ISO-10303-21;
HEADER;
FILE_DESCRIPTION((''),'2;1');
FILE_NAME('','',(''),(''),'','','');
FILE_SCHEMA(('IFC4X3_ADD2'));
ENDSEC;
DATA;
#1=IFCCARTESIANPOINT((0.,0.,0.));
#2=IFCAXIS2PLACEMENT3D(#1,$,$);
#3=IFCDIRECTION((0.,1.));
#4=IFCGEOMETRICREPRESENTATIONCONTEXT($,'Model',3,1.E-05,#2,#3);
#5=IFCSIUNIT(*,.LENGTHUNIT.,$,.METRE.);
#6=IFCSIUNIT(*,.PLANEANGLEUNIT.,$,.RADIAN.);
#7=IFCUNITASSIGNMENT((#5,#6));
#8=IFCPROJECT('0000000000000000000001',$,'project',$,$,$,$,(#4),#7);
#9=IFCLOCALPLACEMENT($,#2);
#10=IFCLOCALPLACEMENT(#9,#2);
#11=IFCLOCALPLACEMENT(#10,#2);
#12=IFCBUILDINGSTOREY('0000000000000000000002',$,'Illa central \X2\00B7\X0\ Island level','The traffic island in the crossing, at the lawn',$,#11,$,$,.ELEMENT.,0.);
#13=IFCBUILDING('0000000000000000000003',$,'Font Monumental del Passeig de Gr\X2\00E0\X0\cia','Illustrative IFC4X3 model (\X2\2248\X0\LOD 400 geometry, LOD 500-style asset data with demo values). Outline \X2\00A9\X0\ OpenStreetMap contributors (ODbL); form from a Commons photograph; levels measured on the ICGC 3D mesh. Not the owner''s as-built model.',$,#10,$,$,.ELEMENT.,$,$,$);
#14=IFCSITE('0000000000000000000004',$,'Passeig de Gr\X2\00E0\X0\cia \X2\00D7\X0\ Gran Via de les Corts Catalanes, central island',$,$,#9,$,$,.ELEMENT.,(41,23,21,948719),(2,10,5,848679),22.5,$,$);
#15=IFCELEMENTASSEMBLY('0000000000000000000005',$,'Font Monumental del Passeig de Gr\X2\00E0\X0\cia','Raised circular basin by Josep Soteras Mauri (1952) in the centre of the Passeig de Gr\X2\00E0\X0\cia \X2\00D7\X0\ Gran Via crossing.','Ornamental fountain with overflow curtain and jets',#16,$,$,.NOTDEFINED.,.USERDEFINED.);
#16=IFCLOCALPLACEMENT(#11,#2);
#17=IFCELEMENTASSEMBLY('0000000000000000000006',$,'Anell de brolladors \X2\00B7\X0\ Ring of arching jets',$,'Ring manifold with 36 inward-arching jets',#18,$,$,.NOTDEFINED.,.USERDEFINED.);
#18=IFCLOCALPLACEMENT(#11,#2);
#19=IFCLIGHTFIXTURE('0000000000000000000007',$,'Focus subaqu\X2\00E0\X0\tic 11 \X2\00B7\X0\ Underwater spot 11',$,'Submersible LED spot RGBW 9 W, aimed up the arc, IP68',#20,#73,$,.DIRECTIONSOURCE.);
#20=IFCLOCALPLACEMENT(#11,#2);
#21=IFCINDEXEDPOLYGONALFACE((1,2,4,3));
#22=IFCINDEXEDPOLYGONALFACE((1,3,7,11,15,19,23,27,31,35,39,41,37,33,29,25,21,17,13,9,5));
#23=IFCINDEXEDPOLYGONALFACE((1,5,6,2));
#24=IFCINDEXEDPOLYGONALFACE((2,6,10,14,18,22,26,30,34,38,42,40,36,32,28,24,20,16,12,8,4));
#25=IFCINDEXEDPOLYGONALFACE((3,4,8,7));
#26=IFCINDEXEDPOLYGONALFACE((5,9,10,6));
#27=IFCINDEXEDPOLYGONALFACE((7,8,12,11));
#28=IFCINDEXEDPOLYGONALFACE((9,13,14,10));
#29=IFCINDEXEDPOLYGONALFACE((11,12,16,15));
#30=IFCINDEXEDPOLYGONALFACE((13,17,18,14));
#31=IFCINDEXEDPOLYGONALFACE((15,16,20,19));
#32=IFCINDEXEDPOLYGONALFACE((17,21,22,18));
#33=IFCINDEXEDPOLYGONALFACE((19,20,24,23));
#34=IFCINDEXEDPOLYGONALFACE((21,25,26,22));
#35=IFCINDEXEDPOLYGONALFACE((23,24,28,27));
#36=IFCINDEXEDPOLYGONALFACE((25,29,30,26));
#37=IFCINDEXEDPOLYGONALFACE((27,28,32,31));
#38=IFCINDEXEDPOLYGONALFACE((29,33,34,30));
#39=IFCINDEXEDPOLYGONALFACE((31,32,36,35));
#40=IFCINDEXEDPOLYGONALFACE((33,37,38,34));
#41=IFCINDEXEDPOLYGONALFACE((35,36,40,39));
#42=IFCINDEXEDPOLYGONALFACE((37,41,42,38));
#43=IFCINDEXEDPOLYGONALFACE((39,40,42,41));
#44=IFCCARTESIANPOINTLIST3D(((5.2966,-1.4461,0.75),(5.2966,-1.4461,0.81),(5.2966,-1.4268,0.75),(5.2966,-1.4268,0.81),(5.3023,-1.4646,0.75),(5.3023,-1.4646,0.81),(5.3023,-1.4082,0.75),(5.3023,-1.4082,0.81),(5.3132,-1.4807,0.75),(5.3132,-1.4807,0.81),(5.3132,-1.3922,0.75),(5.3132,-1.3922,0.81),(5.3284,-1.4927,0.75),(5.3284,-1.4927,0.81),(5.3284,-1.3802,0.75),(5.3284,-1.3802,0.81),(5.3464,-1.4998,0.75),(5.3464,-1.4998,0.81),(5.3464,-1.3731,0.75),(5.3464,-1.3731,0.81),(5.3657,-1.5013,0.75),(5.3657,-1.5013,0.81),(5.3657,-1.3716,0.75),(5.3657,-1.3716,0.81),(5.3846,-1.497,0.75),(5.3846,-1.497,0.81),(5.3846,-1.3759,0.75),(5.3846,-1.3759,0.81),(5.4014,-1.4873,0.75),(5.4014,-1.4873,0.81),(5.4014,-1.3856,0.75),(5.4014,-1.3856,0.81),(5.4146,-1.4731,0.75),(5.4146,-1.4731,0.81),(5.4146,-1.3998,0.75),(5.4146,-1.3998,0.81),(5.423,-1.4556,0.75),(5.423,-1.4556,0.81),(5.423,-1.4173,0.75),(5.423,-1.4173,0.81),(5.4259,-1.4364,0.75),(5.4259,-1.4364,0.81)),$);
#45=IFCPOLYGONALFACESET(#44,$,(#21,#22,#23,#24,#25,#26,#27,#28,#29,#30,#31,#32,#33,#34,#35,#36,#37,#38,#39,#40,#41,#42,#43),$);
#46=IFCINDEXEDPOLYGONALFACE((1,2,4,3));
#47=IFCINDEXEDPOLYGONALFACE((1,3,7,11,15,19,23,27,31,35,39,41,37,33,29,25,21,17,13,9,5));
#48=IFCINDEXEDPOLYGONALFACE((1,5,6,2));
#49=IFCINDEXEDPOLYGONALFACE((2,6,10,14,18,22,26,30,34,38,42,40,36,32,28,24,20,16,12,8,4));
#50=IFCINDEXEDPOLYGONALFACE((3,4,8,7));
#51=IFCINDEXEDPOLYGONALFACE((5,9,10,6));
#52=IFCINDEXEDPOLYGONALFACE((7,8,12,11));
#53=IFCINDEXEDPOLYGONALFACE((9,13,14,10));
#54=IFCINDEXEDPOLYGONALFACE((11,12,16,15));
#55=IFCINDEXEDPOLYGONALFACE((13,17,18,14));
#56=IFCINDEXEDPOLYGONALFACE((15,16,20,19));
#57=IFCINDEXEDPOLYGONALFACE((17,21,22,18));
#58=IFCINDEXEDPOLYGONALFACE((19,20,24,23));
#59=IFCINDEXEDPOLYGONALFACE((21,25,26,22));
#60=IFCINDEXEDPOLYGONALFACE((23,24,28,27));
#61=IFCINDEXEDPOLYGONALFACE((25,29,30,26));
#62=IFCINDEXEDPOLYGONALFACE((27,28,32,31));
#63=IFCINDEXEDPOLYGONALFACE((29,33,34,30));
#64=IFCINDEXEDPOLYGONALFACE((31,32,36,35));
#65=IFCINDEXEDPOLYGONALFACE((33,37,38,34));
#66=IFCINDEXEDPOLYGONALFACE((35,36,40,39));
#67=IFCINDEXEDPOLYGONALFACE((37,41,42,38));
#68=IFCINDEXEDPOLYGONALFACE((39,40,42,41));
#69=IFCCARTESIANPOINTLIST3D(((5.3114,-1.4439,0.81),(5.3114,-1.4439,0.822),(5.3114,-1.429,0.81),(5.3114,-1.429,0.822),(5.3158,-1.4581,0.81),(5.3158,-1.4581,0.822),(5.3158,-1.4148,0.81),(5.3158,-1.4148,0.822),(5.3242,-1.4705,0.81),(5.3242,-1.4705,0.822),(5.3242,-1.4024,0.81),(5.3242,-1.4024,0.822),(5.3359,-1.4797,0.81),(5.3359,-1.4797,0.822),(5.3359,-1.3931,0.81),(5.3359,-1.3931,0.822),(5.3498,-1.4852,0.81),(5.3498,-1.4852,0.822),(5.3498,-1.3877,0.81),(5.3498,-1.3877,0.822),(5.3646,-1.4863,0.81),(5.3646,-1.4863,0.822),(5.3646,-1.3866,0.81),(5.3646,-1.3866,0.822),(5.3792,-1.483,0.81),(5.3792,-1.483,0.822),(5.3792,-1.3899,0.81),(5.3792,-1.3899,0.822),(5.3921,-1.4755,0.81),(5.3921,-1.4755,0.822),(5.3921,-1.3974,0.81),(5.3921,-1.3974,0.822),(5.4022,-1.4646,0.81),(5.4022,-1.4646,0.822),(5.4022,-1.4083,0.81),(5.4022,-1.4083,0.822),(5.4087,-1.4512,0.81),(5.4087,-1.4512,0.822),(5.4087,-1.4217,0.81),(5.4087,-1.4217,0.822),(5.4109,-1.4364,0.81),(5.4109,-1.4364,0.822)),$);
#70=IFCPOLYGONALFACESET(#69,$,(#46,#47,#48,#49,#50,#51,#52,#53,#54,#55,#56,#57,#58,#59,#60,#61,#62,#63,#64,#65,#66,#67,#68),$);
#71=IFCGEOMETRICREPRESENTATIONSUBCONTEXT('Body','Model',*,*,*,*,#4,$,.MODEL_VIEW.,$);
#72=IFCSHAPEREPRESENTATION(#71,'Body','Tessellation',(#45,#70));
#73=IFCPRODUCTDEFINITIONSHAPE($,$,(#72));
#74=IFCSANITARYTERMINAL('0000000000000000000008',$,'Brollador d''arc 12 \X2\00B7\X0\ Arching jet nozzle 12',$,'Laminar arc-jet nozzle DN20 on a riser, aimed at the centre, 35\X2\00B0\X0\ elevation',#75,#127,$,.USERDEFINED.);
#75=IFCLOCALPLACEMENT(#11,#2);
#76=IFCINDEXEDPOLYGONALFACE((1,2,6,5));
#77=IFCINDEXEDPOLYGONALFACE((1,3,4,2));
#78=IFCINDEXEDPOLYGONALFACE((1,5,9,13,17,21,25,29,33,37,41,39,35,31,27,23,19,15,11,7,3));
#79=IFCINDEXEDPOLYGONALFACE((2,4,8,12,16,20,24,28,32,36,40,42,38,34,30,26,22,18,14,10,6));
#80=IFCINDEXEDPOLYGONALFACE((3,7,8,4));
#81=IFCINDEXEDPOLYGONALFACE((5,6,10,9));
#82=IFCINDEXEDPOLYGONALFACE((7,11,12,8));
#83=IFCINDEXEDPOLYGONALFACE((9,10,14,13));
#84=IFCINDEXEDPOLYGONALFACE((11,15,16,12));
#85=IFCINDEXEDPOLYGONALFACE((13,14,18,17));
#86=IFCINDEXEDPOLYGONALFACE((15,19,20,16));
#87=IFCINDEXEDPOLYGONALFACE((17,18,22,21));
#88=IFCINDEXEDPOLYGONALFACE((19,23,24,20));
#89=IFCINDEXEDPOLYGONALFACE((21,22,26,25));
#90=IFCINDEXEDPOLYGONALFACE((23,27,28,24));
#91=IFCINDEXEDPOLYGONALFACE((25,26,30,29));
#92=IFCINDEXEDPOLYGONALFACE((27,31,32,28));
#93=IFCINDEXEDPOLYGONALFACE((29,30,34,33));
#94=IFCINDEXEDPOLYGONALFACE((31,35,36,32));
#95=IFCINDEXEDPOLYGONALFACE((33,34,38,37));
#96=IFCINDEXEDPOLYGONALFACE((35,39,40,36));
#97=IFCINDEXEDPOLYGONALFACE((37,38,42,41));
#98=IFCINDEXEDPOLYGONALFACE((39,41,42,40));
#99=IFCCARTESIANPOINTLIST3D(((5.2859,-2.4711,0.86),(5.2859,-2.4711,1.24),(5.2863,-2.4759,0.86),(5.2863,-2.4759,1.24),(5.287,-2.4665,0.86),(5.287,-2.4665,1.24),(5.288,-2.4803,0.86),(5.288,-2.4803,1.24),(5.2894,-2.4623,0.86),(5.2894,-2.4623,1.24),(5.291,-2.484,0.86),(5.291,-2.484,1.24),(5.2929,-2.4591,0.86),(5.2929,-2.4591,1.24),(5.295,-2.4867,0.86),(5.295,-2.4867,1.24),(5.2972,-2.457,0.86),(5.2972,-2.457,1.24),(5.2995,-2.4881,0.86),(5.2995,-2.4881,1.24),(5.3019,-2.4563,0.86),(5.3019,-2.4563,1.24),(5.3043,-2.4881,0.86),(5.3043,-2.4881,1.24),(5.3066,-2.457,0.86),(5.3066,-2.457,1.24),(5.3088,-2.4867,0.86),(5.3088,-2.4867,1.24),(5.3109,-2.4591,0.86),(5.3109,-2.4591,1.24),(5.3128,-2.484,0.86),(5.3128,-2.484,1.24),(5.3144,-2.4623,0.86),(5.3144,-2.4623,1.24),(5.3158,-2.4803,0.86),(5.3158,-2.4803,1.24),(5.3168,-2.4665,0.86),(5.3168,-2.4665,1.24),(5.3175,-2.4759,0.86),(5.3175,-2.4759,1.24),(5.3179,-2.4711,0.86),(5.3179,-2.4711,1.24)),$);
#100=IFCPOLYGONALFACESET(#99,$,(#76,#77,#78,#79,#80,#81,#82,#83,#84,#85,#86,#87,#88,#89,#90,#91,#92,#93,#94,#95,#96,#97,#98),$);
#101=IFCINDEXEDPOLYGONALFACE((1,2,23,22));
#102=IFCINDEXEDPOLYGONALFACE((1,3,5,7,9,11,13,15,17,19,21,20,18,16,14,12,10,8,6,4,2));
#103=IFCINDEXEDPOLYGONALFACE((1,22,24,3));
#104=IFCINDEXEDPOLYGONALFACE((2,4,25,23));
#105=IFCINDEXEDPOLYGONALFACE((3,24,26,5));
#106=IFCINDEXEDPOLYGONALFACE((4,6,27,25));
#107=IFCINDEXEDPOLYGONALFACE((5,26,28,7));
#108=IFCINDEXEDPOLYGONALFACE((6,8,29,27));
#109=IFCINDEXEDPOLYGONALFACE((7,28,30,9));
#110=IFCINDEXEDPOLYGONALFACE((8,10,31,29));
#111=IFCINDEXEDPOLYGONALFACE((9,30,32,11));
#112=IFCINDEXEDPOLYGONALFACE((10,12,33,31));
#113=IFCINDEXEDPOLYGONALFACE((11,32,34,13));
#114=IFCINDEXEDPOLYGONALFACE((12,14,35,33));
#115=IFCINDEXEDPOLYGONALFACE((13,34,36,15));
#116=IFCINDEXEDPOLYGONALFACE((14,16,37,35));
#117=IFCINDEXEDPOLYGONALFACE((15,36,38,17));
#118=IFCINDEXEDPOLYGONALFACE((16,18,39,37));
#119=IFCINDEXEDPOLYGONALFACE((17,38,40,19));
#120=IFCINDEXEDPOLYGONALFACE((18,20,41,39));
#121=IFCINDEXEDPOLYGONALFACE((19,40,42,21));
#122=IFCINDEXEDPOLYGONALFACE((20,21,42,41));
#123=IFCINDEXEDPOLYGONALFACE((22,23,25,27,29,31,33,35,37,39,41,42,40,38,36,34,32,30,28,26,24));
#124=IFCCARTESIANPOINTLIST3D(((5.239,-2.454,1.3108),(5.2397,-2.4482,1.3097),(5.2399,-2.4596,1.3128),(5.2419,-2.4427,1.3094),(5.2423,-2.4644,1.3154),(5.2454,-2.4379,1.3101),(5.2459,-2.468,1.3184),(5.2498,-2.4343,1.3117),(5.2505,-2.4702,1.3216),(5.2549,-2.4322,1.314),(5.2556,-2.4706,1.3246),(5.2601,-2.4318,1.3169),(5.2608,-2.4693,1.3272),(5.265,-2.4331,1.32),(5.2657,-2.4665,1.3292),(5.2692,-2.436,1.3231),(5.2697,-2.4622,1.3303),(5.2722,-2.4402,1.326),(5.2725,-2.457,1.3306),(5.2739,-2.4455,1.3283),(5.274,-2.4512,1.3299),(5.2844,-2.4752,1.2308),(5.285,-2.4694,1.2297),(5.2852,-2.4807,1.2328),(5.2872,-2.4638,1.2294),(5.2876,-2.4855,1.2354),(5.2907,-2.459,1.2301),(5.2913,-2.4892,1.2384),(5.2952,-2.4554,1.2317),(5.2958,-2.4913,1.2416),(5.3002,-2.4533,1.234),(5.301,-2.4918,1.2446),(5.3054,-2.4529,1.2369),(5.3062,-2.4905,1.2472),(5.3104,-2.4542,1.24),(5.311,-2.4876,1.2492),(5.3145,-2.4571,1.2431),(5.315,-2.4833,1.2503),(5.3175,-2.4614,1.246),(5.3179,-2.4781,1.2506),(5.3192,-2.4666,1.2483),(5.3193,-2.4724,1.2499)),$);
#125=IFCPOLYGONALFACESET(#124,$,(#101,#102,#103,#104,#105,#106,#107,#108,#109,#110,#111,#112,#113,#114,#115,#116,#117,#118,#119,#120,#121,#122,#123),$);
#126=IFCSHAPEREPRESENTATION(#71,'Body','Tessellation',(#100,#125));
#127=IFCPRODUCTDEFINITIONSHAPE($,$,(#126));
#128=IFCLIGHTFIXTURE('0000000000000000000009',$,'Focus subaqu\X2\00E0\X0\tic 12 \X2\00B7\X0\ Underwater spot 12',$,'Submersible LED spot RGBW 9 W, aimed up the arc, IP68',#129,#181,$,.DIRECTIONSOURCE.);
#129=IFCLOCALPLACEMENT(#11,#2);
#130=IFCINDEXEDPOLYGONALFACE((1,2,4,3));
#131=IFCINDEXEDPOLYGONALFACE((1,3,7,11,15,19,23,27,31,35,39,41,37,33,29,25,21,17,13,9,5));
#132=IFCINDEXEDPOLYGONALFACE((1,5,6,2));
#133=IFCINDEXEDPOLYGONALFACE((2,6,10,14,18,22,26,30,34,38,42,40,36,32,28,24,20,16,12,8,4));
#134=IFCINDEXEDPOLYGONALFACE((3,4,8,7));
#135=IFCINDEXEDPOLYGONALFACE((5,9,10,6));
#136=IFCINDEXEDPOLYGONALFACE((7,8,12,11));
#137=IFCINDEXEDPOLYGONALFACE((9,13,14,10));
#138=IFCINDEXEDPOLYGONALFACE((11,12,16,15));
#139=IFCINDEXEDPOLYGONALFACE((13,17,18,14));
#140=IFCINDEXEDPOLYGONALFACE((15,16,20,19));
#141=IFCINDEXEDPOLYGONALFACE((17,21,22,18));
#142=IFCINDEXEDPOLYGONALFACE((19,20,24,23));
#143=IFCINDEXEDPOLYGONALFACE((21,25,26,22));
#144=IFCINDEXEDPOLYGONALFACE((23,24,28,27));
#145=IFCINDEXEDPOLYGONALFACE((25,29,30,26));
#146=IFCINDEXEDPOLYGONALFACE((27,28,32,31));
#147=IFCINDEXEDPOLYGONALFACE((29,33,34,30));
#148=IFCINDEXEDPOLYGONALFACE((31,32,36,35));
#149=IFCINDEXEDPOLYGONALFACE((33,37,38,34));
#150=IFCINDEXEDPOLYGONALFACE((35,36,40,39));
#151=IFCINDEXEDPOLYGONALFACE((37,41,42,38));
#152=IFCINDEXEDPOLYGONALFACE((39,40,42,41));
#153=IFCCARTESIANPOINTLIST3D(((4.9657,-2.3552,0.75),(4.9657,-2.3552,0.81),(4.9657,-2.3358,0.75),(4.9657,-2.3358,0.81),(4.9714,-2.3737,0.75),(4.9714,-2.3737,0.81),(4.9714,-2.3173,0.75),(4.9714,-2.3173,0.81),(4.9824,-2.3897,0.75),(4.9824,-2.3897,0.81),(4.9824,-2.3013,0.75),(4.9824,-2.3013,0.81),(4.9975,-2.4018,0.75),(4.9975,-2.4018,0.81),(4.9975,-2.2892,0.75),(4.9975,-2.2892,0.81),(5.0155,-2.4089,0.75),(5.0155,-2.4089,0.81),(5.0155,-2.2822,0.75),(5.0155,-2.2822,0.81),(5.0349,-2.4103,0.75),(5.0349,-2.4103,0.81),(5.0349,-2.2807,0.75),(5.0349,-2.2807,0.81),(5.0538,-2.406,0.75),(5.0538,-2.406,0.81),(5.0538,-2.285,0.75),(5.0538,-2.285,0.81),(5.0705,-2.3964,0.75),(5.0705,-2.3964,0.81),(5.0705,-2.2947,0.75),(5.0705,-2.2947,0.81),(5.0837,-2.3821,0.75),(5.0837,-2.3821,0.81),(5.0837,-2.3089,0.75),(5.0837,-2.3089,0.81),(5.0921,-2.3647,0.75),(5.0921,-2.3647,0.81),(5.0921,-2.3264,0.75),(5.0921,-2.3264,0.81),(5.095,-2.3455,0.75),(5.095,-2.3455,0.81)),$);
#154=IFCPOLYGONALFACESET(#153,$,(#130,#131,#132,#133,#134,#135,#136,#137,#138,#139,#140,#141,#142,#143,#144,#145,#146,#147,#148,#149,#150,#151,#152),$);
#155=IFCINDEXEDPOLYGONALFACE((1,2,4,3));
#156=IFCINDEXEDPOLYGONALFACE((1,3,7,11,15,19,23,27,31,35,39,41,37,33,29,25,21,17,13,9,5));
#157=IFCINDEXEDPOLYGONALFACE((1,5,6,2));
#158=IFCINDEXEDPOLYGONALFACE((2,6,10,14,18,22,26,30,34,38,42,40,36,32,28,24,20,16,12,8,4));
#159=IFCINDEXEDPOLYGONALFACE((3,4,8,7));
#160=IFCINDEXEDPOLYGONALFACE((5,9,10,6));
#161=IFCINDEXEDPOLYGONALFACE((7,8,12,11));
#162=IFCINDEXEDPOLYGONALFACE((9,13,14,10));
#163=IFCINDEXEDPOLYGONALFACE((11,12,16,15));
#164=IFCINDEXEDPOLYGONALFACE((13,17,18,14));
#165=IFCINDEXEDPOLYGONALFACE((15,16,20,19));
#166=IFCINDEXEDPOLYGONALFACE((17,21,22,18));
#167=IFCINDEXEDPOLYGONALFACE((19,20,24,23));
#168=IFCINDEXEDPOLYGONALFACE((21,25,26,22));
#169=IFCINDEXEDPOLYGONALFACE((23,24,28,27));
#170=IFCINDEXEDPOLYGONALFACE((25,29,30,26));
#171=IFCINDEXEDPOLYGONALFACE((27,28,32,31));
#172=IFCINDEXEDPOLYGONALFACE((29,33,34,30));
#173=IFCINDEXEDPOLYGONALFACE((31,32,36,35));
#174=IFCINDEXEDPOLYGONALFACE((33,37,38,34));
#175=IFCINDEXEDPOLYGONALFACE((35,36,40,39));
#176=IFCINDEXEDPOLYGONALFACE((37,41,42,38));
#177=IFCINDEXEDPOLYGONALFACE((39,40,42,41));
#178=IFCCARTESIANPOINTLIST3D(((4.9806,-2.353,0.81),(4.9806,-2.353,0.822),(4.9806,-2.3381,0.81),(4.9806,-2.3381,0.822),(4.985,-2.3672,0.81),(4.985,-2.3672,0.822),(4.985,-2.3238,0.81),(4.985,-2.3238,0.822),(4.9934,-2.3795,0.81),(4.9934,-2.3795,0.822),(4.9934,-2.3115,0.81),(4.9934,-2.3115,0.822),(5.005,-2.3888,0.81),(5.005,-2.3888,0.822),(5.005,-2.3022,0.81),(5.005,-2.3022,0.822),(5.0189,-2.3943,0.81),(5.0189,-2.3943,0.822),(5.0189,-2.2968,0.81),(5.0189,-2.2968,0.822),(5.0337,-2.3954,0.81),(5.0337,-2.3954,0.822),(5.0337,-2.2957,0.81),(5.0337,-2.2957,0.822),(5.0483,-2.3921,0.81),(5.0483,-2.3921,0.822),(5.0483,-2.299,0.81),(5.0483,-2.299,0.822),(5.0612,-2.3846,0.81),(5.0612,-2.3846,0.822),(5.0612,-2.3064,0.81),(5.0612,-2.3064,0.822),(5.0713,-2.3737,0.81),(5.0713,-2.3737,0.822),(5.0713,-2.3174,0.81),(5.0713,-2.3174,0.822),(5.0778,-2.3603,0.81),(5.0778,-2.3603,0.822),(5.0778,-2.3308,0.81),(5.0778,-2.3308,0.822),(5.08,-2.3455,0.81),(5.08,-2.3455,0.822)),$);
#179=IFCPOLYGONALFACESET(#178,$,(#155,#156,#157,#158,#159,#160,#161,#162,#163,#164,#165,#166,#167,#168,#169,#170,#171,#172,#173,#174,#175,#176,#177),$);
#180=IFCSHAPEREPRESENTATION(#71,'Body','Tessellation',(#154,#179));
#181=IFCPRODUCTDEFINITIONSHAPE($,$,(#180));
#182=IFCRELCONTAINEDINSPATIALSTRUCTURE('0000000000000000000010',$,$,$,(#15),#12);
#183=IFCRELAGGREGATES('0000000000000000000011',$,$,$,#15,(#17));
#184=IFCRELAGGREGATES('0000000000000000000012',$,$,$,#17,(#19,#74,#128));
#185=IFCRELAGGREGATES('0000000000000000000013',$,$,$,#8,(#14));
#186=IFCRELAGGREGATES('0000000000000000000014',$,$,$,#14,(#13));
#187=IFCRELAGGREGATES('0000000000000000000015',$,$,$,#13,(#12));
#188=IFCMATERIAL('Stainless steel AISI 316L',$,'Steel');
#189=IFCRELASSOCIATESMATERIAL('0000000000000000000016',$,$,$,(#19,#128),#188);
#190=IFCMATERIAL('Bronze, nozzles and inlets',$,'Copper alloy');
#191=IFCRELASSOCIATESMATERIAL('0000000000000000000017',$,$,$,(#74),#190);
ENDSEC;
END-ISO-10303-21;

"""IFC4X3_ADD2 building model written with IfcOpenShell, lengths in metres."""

from ifc_helpers import new_model, si_unit, direction, frame, origin, origin_2d_with_axis, place, context, subcontext, project, spatial, circle, extrude, material, element, aggregate, save


model = new_model("IFC4X3_ADD2")

# Units and contexts
model_context = context("Model", 3, precision=1e-05, world=origin(), true_north=direction((0.0, 1.0)))
body_context = subcontext(model_context, "Body", "Model", "MODEL_VIEW")
ifc_project = project(units=[si_unit("LENGTHUNIT", "METRE"), si_unit("PLANEANGLEUNIT", "RADIAN")], contexts=[model_context])

# Site, building, storey
site_placement = place(None, origin())
site = spatial("IfcSite", under=ifc_project, at=site_placement, Name="Passeig de Gràcia × Gran Via de les Corts Catalanes, central island", CompositionType="ELEMENT", RefLatitude=(41, 23, 21, 948719), RefLongitude=(2, 10, 5, 848679), RefElevation=22.5)
building_placement = place(site_placement, origin())
building = spatial("IfcBuilding", under=site, at=building_placement, Name="Font Monumental del Passeig de Gràcia", Description="Illustrative IFC4X3 model (≈LOD 400 geometry, LOD 500-style asset data with demo values). Outline © OpenStreetMap contributors (ODbL); form from a Commons photograph; levels measured on the ICGC 3D mesh. Not the owner's as-built model.", CompositionType="ELEMENT")
storey_placement = place(building_placement, origin())
storey = spatial("IfcBuildingStorey", under=building, at=storey_placement, Name="Illa central · Island level", Description="The traffic island in the crossing, at the lawn", CompositionType="ELEMENT", Elevation=0.0)

# Element assemblies, light fixtures, sanitary terminal
assembly_1_placement = place(building_placement, origin())
assembly_1 = element("IfcElementAssembly", 1, at=assembly_1_placement, inside=storey, Name="Font Monumental del Passeig de Gràcia", Description="Raised circular basin by Josep Soteras Mauri (1952) in the centre of the Passeig de Gràcia × Gran Via crossing.", ObjectType="Ornamental fountain with overflow curtain and jets", AssemblyPlace="NOTDEFINED", PredefinedType="USERDEFINED")
assembly_2_placement = place(building_placement, origin())
assembly_2 = element("IfcElementAssembly", 2, at=assembly_2_placement, Name="Anell de brolladors · Ring of arching jets", ObjectType="Ring manifold with 36 inward-arching jets", AssemblyPlace="NOTDEFINED", PredefinedType="USERDEFINED")
aggregate(assembly_1, [assembly_2])
ifc_material_1 = material(Name="Bronze, nozzles and inlets", Category="Copper alloy")
ifc_material_2 = material(Name="Stainless steel AISI 316L", Category="Steel")
light_fixture_1_placement = place(building_placement, origin())
light_fixture_1 = element("IfcLightFixture", 3, at=light_fixture_1_placement, material=ifc_material_2, Name="Focus subaquàtic 11 · Underwater spot 11", ObjectType="Submersible LED spot RGBW 9 W, aimed up the arc, IP68", PredefinedType="DIRECTIONSOURCE", context=body_context, shape_type="SweptSolid", body=[
    extrude(circle(Radius=0.065, at=origin_2d_with_axis()), frame((5.3609, -1.4364, 0.75)), (0.0, 0.0, 1.0), 0.06),
    extrude(circle(Radius=0.05, at=origin_2d_with_axis()), frame((5.3609, -1.4364, 0.81)), (0.0, 0.0, 1.0), 0.012),
])
sanitary_terminal_1_placement = place(building_placement, origin())
sanitary_terminal_1 = element("IfcSanitaryTerminal", 4, at=sanitary_terminal_1_placement, material=ifc_material_1, Name="Brollador d'arc 12 · Arching jet nozzle 12", ObjectType="Laminar arc-jet nozzle DN20 on a riser, aimed at the centre, 35° elevation", PredefinedType="USERDEFINED", context=body_context, shape_type="SweptSolid", body=[
    extrude(circle(Radius=0.016, at=origin_2d_with_axis()), frame((5.3019, -2.4723, 0.86), z_axis=(0.0, 0.0, 1.0), x_axis=(0.0, 1.0, 0.0)), (0.0, 0.0, 1.0), 0.38),
    extrude(circle(Radius=0.02, at=origin_2d_with_axis()), frame((5.3019, -2.4723, 1.24), z_axis=(-0.480342, 0.223987, 0.847998), x_axis=(0.422618, 0.906308, 0.0)), (0.0, 0.0, 1.0), 0.0943),
])
light_fixture_2_placement = place(building_placement, origin())
light_fixture_2 = element("IfcLightFixture", 5, at=light_fixture_2_placement, material=ifc_material_2, Name="Focus subaquàtic 12 · Underwater spot 12", ObjectType="Submersible LED spot RGBW 9 W, aimed up the arc, IP68", PredefinedType="DIRECTIONSOURCE", context=body_context, shape_type="SweptSolid", body=[
    extrude(circle(Radius=0.065, at=origin_2d_with_axis()), frame((5.03, -2.3455, 0.75)), (0.0, 0.0, 1.0), 0.06),
    extrude(circle(Radius=0.05, at=origin_2d_with_axis()), frame((5.03, -2.3455, 0.81)), (0.0, 0.0, 1.0), 0.012),
])
aggregate(assembly_2, [light_fixture_1, sanitary_terminal_1, light_fixture_2])

save(model, "model.ifc")
